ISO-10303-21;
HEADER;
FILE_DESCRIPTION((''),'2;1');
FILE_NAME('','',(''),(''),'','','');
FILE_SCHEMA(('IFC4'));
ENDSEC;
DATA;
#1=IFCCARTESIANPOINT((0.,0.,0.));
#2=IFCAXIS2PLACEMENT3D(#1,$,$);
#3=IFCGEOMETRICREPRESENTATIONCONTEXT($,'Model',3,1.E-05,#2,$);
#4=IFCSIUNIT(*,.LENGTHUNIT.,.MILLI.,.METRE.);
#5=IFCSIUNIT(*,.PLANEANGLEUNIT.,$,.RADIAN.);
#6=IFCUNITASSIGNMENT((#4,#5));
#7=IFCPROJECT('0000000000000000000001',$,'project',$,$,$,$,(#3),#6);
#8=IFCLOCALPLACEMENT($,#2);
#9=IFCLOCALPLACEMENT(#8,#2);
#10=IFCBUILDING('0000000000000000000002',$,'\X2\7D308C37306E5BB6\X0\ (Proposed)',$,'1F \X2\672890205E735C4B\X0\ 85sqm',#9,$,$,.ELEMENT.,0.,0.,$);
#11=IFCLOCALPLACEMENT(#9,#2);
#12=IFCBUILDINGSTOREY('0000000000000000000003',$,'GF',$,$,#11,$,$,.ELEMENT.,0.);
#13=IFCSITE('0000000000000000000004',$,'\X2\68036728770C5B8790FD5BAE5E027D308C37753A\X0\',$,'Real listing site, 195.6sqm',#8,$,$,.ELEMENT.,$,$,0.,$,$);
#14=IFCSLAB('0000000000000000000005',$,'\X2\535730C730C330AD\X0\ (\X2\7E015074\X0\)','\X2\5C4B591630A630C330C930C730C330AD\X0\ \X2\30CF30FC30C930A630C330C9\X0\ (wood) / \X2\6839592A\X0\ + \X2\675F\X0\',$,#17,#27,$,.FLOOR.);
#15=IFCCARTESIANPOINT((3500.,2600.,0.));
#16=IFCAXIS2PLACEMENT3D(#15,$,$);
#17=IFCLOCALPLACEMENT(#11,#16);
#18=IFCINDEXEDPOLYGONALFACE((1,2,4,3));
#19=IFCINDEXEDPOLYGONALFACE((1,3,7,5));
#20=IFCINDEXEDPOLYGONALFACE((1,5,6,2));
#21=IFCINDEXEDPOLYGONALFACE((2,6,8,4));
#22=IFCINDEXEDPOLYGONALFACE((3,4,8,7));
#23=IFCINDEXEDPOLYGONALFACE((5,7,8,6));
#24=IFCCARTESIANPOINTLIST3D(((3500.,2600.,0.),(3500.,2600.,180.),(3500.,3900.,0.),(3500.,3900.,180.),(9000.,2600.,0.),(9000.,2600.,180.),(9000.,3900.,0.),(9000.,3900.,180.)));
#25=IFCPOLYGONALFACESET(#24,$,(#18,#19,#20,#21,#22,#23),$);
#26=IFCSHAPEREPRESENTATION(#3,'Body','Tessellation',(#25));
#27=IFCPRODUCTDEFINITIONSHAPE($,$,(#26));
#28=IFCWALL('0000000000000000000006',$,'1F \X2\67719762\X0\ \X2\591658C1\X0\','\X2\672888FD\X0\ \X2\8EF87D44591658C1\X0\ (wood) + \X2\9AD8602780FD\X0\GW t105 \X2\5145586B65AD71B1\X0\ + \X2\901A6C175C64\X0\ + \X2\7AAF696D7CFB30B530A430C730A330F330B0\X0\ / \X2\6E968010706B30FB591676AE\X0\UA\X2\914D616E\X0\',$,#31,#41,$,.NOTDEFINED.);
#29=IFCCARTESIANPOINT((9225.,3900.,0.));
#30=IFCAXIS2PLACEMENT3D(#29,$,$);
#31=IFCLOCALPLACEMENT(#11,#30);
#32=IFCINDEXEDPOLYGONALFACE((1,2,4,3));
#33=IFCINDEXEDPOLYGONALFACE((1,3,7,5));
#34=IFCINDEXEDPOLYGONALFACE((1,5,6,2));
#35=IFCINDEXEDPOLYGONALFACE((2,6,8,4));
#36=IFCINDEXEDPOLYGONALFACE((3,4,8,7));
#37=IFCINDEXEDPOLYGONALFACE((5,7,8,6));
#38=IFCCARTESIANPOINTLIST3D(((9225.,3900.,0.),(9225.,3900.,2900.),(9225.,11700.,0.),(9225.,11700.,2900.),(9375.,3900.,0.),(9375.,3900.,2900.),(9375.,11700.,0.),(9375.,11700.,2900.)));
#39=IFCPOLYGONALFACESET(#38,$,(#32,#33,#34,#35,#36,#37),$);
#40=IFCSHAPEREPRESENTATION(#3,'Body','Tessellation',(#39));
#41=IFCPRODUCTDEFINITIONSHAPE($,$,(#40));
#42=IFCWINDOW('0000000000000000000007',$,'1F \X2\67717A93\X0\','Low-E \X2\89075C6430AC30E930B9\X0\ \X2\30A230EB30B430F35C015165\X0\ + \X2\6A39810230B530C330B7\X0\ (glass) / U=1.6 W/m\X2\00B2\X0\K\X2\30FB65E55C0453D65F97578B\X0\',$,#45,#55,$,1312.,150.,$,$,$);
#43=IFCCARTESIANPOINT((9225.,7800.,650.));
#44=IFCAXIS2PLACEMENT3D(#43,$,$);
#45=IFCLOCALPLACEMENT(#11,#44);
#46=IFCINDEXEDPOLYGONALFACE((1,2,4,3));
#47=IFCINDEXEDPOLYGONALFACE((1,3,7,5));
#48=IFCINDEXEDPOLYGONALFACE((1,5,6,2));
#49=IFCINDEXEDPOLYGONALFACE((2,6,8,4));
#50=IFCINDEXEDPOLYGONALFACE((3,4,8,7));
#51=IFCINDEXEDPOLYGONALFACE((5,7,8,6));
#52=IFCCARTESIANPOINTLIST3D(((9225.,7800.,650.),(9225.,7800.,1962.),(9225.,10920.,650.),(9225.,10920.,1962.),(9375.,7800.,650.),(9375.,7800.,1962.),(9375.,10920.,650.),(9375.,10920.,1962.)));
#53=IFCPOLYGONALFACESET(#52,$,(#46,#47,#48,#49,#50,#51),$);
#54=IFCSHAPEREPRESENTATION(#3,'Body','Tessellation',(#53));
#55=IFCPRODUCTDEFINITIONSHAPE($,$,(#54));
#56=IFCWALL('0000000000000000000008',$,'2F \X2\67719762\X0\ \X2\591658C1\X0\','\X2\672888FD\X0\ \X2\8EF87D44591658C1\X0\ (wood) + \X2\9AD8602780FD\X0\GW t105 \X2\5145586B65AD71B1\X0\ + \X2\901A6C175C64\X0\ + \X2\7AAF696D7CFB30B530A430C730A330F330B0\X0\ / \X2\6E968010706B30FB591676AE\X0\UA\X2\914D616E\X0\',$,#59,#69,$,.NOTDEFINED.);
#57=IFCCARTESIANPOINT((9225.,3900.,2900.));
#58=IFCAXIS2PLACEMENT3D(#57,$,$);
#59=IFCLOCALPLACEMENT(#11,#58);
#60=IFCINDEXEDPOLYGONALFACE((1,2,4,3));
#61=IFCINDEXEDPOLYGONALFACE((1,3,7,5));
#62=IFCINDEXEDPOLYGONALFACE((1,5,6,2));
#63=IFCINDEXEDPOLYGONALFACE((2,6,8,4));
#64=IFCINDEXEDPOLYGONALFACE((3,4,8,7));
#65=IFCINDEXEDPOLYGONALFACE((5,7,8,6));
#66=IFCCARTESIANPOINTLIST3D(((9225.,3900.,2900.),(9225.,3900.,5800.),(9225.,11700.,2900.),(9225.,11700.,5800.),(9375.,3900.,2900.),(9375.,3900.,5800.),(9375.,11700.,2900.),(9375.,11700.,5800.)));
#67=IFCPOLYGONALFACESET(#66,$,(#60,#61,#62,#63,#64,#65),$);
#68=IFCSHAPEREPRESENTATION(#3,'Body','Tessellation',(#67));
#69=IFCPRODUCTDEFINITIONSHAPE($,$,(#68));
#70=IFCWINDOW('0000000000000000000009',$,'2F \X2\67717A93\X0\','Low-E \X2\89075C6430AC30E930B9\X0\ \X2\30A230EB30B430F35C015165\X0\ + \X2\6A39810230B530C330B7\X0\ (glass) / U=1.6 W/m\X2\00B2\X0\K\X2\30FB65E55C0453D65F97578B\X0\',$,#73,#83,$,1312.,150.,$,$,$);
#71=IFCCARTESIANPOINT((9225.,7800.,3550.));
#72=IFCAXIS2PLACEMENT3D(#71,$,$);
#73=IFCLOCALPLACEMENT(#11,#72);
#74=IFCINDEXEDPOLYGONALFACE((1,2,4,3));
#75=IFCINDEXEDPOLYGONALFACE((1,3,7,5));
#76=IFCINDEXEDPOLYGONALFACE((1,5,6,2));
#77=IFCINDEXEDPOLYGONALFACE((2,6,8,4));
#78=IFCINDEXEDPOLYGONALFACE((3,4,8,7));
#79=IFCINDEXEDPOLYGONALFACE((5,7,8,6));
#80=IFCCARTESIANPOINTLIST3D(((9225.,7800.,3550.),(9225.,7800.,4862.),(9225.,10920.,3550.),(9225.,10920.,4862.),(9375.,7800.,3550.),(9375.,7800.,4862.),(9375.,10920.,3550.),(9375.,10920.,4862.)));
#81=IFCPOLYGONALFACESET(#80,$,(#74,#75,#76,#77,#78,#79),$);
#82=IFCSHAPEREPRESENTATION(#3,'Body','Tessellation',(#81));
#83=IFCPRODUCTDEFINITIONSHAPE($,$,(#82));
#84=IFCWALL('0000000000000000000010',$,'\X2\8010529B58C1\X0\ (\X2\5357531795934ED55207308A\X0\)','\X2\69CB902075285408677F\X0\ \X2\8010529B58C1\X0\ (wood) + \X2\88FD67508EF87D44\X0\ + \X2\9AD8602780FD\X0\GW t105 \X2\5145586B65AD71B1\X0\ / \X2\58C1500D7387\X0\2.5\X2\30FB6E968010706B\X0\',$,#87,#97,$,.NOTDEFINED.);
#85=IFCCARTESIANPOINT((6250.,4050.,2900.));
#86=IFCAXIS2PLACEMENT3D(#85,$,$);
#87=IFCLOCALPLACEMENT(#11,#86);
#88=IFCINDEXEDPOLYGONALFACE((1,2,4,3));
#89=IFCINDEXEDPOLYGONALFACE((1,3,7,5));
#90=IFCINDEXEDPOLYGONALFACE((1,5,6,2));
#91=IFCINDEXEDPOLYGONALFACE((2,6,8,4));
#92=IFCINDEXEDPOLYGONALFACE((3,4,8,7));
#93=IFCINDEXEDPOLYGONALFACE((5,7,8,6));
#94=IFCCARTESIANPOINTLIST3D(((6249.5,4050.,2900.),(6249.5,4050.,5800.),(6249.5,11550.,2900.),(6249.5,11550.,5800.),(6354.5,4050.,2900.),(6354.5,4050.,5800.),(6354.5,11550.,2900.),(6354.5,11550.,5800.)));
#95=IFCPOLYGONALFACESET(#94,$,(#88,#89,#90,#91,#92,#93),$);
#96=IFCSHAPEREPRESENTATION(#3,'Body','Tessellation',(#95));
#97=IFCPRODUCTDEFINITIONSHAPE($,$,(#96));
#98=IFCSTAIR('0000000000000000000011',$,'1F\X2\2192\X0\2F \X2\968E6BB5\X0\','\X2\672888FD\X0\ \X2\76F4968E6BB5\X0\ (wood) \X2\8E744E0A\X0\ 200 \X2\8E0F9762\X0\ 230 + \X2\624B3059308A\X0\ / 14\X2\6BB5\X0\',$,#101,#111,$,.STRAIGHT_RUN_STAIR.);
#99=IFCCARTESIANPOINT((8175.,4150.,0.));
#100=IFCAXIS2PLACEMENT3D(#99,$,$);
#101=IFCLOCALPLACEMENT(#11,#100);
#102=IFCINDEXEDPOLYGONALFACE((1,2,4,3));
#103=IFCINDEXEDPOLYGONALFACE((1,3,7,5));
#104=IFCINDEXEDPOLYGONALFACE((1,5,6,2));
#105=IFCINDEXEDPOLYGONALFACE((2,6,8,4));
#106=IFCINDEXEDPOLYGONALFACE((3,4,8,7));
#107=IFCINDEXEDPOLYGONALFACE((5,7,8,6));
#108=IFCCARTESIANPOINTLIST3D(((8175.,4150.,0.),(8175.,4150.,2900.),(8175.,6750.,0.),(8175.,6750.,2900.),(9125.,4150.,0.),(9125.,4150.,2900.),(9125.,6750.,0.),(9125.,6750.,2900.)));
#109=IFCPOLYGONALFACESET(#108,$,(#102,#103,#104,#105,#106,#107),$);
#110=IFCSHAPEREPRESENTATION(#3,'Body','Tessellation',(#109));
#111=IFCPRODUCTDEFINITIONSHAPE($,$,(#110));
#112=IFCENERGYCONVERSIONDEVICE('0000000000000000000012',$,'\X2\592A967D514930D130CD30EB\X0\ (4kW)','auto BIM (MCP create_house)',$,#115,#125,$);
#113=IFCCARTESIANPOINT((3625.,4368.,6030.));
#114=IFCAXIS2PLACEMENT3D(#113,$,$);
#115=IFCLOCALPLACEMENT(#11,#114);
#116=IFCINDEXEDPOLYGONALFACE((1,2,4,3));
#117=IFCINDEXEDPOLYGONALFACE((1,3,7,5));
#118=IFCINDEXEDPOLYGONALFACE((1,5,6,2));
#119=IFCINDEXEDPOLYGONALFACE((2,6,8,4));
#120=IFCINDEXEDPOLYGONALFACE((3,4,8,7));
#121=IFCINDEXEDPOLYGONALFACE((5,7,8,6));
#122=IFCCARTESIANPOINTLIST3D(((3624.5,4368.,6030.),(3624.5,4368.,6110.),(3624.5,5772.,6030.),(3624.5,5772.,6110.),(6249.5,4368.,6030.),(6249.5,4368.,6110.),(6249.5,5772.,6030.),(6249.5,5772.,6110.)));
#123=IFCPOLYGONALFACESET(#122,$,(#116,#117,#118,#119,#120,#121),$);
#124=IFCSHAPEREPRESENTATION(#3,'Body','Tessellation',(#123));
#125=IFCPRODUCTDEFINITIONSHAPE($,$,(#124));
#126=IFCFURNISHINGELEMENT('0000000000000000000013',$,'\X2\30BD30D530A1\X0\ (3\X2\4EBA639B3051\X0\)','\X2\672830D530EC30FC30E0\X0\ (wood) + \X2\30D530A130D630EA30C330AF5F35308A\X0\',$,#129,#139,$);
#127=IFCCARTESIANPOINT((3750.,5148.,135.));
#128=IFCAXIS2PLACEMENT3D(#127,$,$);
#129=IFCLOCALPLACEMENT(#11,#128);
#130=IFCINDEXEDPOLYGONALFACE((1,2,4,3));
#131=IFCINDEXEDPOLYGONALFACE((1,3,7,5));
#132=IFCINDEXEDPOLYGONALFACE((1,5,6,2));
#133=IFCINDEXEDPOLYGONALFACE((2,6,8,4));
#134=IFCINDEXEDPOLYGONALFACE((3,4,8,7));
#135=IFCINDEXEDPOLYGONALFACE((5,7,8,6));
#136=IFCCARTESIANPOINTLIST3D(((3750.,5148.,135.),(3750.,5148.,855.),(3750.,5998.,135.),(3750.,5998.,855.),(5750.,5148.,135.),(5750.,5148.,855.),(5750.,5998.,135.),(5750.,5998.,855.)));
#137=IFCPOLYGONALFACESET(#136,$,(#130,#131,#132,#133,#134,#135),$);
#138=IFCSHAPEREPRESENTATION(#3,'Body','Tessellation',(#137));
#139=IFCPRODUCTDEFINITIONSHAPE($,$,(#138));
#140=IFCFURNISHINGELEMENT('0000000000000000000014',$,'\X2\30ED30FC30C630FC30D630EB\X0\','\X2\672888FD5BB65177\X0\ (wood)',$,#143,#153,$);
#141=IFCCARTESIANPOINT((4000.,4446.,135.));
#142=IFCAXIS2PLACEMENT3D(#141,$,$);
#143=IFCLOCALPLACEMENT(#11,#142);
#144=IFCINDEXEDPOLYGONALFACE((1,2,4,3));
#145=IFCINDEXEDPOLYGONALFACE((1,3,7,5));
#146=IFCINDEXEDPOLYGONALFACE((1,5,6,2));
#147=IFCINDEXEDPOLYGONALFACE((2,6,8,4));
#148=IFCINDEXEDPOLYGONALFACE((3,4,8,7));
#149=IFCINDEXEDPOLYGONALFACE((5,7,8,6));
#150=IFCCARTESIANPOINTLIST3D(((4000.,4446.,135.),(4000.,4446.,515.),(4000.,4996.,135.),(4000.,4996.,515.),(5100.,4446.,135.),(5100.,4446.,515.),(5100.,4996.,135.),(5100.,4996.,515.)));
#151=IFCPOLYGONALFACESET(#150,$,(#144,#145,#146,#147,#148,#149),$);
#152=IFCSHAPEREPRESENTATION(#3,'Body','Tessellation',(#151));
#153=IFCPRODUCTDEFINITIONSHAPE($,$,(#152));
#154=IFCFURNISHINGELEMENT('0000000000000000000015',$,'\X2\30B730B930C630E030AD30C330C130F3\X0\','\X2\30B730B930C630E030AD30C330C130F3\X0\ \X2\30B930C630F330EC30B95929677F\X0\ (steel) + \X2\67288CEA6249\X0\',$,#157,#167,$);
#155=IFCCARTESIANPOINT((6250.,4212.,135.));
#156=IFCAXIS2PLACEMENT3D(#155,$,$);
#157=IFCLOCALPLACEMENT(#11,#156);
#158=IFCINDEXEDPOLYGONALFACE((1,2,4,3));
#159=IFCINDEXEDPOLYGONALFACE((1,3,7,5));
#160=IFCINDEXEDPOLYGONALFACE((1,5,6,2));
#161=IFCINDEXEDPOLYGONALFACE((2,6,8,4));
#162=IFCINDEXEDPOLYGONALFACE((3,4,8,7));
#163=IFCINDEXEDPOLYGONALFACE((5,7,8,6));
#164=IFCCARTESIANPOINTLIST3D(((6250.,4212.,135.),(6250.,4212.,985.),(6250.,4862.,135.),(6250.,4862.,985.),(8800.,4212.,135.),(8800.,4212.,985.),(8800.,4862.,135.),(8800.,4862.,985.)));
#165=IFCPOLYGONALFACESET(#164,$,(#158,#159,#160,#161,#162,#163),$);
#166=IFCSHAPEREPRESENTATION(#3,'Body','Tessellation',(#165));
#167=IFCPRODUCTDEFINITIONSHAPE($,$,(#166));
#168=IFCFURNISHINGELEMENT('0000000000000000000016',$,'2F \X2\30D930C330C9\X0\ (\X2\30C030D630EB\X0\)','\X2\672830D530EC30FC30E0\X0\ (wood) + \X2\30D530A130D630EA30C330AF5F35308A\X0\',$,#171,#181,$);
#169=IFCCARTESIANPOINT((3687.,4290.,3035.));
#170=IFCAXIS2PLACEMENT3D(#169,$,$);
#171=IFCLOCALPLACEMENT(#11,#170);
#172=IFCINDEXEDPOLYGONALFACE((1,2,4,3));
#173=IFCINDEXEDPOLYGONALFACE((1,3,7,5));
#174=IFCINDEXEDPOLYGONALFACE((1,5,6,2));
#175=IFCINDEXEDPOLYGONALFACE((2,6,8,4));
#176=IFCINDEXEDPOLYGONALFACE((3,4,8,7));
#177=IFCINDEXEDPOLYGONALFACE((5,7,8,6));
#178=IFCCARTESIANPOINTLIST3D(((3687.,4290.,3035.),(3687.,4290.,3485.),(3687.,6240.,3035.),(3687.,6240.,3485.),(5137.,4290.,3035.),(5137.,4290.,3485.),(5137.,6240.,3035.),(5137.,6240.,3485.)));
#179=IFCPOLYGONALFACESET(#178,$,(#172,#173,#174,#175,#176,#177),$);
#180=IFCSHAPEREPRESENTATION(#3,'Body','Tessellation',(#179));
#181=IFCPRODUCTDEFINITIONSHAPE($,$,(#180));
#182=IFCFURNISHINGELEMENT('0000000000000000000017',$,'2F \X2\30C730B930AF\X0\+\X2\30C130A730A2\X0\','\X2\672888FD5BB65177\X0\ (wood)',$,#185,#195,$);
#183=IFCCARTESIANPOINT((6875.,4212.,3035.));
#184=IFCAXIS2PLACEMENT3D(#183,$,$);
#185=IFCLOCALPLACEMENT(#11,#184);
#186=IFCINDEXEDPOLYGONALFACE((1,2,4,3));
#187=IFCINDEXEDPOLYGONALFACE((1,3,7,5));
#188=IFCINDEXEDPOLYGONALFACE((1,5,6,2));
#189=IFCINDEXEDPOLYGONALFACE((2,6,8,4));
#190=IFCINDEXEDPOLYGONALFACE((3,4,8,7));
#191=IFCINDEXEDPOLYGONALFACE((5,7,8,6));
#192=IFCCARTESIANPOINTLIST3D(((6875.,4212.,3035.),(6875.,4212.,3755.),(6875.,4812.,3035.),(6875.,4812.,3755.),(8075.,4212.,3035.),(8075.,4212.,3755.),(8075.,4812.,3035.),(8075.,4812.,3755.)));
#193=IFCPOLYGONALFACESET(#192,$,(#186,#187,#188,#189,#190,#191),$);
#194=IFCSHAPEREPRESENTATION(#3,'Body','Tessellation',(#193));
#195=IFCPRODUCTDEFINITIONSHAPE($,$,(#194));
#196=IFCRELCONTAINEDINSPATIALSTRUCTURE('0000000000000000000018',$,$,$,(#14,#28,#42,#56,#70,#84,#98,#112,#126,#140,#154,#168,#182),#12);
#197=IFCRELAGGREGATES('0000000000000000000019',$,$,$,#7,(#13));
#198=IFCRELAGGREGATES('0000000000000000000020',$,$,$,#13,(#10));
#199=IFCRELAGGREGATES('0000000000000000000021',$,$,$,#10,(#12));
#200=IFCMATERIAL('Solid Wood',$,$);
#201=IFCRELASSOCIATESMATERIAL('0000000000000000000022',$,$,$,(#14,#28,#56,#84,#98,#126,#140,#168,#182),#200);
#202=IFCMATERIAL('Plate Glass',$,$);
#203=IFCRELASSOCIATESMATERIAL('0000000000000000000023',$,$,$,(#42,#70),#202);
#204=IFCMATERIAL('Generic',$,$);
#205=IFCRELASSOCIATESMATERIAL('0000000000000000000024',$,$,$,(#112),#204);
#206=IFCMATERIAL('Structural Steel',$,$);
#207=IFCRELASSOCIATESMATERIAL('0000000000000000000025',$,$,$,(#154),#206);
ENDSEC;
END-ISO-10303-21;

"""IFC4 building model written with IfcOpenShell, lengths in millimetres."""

from ifc_helpers import new_model, si_unit, frame, frame_2d, origin, place, context, project, spatial, rectangle, extrude, material, element, fill, save


model = new_model("IFC4")

# Units and contexts
model_context = context("Model", 3, precision=1e-05, world=origin())
ifc_project = project(units=[si_unit("LENGTHUNIT", "METRE", prefix="MILLI"), si_unit("PLANEANGLEUNIT", "RADIAN")], contexts=[model_context])

# Site, building, storey
site_placement = place(None, origin())
site = spatial("IfcSite", under=ifc_project, at=site_placement, Name="栃木県宇都宮市細谷町", ObjectType="Real listing site, 195.6sqm", CompositionType="ELEMENT", RefElevation=0.0)
building_placement = place(site_placement, origin())
building = spatial("IfcBuilding", under=site, at=building_placement, Name="細谷の家 (Proposed)", ObjectType="1F 木造平屋 85sqm", CompositionType="ELEMENT", ElevationOfRefHeight=0.0, ElevationOfTerrain=0.0)
storey_placement = place(building_placement, origin())
storey = spatial("IfcBuildingStorey", under=building, at=storey_placement, Name="GF", CompositionType="ELEMENT", Elevation=0.0)

# Slab
ifc_material_1 = material(Name="Solid Wood")
slab_placement = place(storey_placement, frame((3500.0, 2600.0, 0.0)))
element("IfcSlab", 1, at=slab_placement, inside=storey, material=ifc_material_1, Name="南デッキ (縁側)", Description="屋外ウッドデッキ ハードウッド (wood) / 根太 + 束", PredefinedType="FLOOR", context=model_context, shape_type="SweptSolid", body=[
    extrude(rectangle(XDim=5500.0, YDim=1300.0, at=frame_2d((2750.0, 650.0))), frame((3500.0, 2600.0, 0.0)), (0.0, 0.0, 1.0), 180.0),
])

# Wall, opening, window
wall_1_placement = place(storey_placement, frame((9225.0, 3900.0, 0.0)))
wall_1 = element("IfcWall", 2, at=wall_1_placement, inside=storey, material=ifc_material_1, Name="1F 東面 外壁", Description="木製 軸組外壁 (wood) + 高性能GW t105 充填断熱 + 通気層 + 窯業系サイディング / 準耐火・外皮UA配慮", PredefinedType="NOTDEFINED", context=model_context, shape_type="SweptSolid", body=[
    extrude(rectangle(XDim=150.0, YDim=7800.0, at=frame_2d((75.0, 3900.0))), frame((9225.0, 3900.0, 0.0)), (0.0, 0.0, 1.0), 2900.0),
])
opening_1_placement = place(storey_placement, frame((9225.0, 7800.0, 650.0)))
opening_1 = element("IfcOpeningElement", 3, at=opening_1_placement, cuts=wall_1, PredefinedType="NOTDEFINED", context=model_context, shape_type="SweptSolid", body=[
    extrude(rectangle(XDim=150.0, YDim=3120.0, at=frame_2d((75.0, 1560.0))), frame((9225.0, 7800.0, 650.0)), (0.0, 0.0, 1.0), 1312.0),
])
ifc_material_2 = material(Name="Plate Glass")
window_1_placement = place(storey_placement, frame((9225.0, 7800.0, 650.0)))
window_1 = element("IfcWindow", 4, at=window_1_placement, inside=storey, material=ifc_material_2, Name="1F 東窓", Description="Low-E 複層ガラス アルゴン封入 + 樹脂サッシ (glass) / U=1.6 W/m²K・日射取得型", OverallHeight=1312.0, OverallWidth=150.0, context=model_context, shape_type="SweptSolid", body=[
    extrude(rectangle(XDim=150.0, YDim=3120.0, at=frame_2d((75.0, 1560.0))), frame((9225.0, 7800.0, 650.0)), (0.0, 0.0, 1.0), 1312.0),
])
fill(opening_1, window_1)

# Wall, opening, window
wall_2_placement = place(storey_placement, frame((9225.0, 3900.0, 2900.0)))
wall_2 = element("IfcWall", 5, at=wall_2_placement, inside=storey, material=ifc_material_1, Name="2F 東面 外壁", Description="木製 軸組外壁 (wood) + 高性能GW t105 充填断熱 + 通気層 + 窯業系サイディング / 準耐火・外皮UA配慮", PredefinedType="NOTDEFINED", context=model_context, shape_type="SweptSolid", body=[
    extrude(rectangle(XDim=150.0, YDim=7800.0, at=frame_2d((75.0, 3900.0))), frame((9225.0, 3900.0, 2900.0)), (0.0, 0.0, 1.0), 2900.0),
])
opening_2_placement = place(storey_placement, frame((9225.0, 7800.0, 3550.0)))
opening_2 = element("IfcOpeningElement", 6, at=opening_2_placement, cuts=wall_2, PredefinedType="NOTDEFINED", context=model_context, shape_type="SweptSolid", body=[
    extrude(rectangle(XDim=150.0, YDim=3120.0, at=frame_2d((75.0, 1560.0))), frame((9225.0, 7800.0, 3550.0)), (0.0, 0.0, 1.0), 1312.0),
])
window_2_placement = place(storey_placement, frame((9225.0, 7800.0, 3550.0)))
window_2 = element("IfcWindow", 7, at=window_2_placement, inside=storey, material=ifc_material_2, Name="2F 東窓", Description="Low-E 複層ガラス アルゴン封入 + 樹脂サッシ (glass) / U=1.6 W/m²K・日射取得型", OverallHeight=1312.0, OverallWidth=150.0, context=model_context, shape_type="SweptSolid", body=[
    extrude(rectangle(XDim=150.0, YDim=3120.0, at=frame_2d((75.0, 1560.0))), frame((9225.0, 7800.0, 3550.0)), (0.0, 0.0, 1.0), 1312.0),
])
fill(opening_2, window_2)

# Wall
wall_3_placement = place(storey_placement, frame((6250.0, 4050.0, 2900.0)))
element("IfcWall", 8, at=wall_3_placement, inside=storey, material=ifc_material_1, Name="耐力壁 (南北間仕切り)", Description="構造用合板 耐力壁 (wood) + 製材軸組 + 高性能GW t105 充填断熱 / 壁倍率2.5・準耐火", PredefinedType="NOTDEFINED", context=model_context, shape_type="SweptSolid", body=[
    extrude(rectangle(XDim=105.0, YDim=7500.0, at=frame_2d((52.0, 3750.0))), frame((6250.0, 4050.0, 2900.0)), (0.0, 0.0, 1.0), 2900.0),
])

# Stair
stair_placement = place(storey_placement, frame((8175.0, 4150.0, 0.0)))
element("IfcStair", 9, at=stair_placement, inside=storey, material=ifc_material_1, Name="1F→2F 階段", Description="木製 直階段 (wood) 蹴上 200 踏面 230 + 手すり / 14段", PredefinedType="STRAIGHT_RUN_STAIR", context=model_context, shape_type="SweptSolid", body=[
    extrude(rectangle(XDim=950.0, YDim=2600.0, at=frame_2d((475.0, 1300.0))), frame((8175.0, 4150.0, 0.0)), (0.0, 0.0, 1.0), 2900.0),
])

# Energy conversion device
ifc_material_3 = material(Name="Generic")
energy_conversion_device_placement = place(storey_placement, frame((3625.0, 4368.0, 6030.0)))
element("IfcEnergyConversionDevice", 10, at=energy_conversion_device_placement, inside=storey, material=ifc_material_3, Name="太陽光パネル (4kW)", Description="auto BIM (MCP create_house)", context=model_context, shape_type="SweptSolid", body=[
    extrude(rectangle(XDim=2625.0, YDim=1404.0, at=frame_2d((1312.0, 702.0))), frame((3625.0, 4368.0, 6030.0)), (0.0, 0.0, 1.0), 80.0),
])

# Furnishing elements
furnishing_1_placement = place(storey_placement, frame((3750.0, 5148.0, 135.0)))
element("IfcFurnishingElement", 11, at=furnishing_1_placement, inside=storey, material=ifc_material_1, Name="ソファ (3人掛け)", Description="木フレーム (wood) + ファブリック張り", context=model_context, shape_type="SweptSolid", body=[
    extrude(rectangle(XDim=2000.0, YDim=850.0, at=frame_2d((1000.0, 425.0))), frame((3750.0, 5148.0, 135.0)), (0.0, 0.0, 1.0), 720.0),
])
furnishing_2_placement = place(storey_placement, frame((4000.0, 4446.0, 135.0)))
element("IfcFurnishingElement", 12, at=furnishing_2_placement, inside=storey, material=ifc_material_1, Name="ローテーブル", Description="木製家具 (wood)", context=model_context, shape_type="SweptSolid", body=[
    extrude(rectangle(XDim=1100.0, YDim=550.0, at=frame_2d((550.0, 275.0))), frame((4000.0, 4446.0, 135.0)), (0.0, 0.0, 1.0), 380.0),
])
ifc_material_4 = material(Name="Structural Steel")
furnishing_3_placement = place(storey_placement, frame((6250.0, 4212.0, 135.0)))
element("IfcFurnishingElement", 13, at=furnishing_3_placement, inside=storey, material=ifc_material_4, Name="システムキッチン", Description="システムキッチン ステンレス天板 (steel) + 木質扉", context=model_context, shape_type="SweptSolid", body=[
    extrude(rectangle(XDim=2550.0, YDim=650.0, at=frame_2d((1275.0, 325.0))), frame((6250.0, 4212.0, 135.0)), (0.0, 0.0, 1.0), 850.0),
])
furnishing_4_placement = place(storey_placement, frame((3687.0, 4290.0, 3035.0)))
element("IfcFurnishingElement", 14, at=furnishing_4_placement, inside=storey, material=ifc_material_1, Name="2F ベッド (ダブル)", Description="木フレーム (wood) + ファブリック張り", context=model_context, shape_type="SweptSolid", body=[
    extrude(rectangle(XDim=1450.0, YDim=1950.0, at=frame_2d((725.0, 975.0))), frame((3687.0, 4290.0, 3035.0)), (0.0, 0.0, 1.0), 450.0),
])
furnishing_5_placement = place(storey_placement, frame((6875.0, 4212.0, 3035.0)))
element("IfcFurnishingElement", 15, at=furnishing_5_placement, inside=storey, material=ifc_material_1, Name="2F デスク+チェア", Description="木製家具 (wood)", context=model_context, shape_type="SweptSolid", body=[
    extrude(rectangle(XDim=1200.0, YDim=600.0, at=frame_2d((600.0, 300.0))), frame((6875.0, 4212.0, 3035.0)), (0.0, 0.0, 1.0), 720.0),
])

save(model, "model.ifc")
